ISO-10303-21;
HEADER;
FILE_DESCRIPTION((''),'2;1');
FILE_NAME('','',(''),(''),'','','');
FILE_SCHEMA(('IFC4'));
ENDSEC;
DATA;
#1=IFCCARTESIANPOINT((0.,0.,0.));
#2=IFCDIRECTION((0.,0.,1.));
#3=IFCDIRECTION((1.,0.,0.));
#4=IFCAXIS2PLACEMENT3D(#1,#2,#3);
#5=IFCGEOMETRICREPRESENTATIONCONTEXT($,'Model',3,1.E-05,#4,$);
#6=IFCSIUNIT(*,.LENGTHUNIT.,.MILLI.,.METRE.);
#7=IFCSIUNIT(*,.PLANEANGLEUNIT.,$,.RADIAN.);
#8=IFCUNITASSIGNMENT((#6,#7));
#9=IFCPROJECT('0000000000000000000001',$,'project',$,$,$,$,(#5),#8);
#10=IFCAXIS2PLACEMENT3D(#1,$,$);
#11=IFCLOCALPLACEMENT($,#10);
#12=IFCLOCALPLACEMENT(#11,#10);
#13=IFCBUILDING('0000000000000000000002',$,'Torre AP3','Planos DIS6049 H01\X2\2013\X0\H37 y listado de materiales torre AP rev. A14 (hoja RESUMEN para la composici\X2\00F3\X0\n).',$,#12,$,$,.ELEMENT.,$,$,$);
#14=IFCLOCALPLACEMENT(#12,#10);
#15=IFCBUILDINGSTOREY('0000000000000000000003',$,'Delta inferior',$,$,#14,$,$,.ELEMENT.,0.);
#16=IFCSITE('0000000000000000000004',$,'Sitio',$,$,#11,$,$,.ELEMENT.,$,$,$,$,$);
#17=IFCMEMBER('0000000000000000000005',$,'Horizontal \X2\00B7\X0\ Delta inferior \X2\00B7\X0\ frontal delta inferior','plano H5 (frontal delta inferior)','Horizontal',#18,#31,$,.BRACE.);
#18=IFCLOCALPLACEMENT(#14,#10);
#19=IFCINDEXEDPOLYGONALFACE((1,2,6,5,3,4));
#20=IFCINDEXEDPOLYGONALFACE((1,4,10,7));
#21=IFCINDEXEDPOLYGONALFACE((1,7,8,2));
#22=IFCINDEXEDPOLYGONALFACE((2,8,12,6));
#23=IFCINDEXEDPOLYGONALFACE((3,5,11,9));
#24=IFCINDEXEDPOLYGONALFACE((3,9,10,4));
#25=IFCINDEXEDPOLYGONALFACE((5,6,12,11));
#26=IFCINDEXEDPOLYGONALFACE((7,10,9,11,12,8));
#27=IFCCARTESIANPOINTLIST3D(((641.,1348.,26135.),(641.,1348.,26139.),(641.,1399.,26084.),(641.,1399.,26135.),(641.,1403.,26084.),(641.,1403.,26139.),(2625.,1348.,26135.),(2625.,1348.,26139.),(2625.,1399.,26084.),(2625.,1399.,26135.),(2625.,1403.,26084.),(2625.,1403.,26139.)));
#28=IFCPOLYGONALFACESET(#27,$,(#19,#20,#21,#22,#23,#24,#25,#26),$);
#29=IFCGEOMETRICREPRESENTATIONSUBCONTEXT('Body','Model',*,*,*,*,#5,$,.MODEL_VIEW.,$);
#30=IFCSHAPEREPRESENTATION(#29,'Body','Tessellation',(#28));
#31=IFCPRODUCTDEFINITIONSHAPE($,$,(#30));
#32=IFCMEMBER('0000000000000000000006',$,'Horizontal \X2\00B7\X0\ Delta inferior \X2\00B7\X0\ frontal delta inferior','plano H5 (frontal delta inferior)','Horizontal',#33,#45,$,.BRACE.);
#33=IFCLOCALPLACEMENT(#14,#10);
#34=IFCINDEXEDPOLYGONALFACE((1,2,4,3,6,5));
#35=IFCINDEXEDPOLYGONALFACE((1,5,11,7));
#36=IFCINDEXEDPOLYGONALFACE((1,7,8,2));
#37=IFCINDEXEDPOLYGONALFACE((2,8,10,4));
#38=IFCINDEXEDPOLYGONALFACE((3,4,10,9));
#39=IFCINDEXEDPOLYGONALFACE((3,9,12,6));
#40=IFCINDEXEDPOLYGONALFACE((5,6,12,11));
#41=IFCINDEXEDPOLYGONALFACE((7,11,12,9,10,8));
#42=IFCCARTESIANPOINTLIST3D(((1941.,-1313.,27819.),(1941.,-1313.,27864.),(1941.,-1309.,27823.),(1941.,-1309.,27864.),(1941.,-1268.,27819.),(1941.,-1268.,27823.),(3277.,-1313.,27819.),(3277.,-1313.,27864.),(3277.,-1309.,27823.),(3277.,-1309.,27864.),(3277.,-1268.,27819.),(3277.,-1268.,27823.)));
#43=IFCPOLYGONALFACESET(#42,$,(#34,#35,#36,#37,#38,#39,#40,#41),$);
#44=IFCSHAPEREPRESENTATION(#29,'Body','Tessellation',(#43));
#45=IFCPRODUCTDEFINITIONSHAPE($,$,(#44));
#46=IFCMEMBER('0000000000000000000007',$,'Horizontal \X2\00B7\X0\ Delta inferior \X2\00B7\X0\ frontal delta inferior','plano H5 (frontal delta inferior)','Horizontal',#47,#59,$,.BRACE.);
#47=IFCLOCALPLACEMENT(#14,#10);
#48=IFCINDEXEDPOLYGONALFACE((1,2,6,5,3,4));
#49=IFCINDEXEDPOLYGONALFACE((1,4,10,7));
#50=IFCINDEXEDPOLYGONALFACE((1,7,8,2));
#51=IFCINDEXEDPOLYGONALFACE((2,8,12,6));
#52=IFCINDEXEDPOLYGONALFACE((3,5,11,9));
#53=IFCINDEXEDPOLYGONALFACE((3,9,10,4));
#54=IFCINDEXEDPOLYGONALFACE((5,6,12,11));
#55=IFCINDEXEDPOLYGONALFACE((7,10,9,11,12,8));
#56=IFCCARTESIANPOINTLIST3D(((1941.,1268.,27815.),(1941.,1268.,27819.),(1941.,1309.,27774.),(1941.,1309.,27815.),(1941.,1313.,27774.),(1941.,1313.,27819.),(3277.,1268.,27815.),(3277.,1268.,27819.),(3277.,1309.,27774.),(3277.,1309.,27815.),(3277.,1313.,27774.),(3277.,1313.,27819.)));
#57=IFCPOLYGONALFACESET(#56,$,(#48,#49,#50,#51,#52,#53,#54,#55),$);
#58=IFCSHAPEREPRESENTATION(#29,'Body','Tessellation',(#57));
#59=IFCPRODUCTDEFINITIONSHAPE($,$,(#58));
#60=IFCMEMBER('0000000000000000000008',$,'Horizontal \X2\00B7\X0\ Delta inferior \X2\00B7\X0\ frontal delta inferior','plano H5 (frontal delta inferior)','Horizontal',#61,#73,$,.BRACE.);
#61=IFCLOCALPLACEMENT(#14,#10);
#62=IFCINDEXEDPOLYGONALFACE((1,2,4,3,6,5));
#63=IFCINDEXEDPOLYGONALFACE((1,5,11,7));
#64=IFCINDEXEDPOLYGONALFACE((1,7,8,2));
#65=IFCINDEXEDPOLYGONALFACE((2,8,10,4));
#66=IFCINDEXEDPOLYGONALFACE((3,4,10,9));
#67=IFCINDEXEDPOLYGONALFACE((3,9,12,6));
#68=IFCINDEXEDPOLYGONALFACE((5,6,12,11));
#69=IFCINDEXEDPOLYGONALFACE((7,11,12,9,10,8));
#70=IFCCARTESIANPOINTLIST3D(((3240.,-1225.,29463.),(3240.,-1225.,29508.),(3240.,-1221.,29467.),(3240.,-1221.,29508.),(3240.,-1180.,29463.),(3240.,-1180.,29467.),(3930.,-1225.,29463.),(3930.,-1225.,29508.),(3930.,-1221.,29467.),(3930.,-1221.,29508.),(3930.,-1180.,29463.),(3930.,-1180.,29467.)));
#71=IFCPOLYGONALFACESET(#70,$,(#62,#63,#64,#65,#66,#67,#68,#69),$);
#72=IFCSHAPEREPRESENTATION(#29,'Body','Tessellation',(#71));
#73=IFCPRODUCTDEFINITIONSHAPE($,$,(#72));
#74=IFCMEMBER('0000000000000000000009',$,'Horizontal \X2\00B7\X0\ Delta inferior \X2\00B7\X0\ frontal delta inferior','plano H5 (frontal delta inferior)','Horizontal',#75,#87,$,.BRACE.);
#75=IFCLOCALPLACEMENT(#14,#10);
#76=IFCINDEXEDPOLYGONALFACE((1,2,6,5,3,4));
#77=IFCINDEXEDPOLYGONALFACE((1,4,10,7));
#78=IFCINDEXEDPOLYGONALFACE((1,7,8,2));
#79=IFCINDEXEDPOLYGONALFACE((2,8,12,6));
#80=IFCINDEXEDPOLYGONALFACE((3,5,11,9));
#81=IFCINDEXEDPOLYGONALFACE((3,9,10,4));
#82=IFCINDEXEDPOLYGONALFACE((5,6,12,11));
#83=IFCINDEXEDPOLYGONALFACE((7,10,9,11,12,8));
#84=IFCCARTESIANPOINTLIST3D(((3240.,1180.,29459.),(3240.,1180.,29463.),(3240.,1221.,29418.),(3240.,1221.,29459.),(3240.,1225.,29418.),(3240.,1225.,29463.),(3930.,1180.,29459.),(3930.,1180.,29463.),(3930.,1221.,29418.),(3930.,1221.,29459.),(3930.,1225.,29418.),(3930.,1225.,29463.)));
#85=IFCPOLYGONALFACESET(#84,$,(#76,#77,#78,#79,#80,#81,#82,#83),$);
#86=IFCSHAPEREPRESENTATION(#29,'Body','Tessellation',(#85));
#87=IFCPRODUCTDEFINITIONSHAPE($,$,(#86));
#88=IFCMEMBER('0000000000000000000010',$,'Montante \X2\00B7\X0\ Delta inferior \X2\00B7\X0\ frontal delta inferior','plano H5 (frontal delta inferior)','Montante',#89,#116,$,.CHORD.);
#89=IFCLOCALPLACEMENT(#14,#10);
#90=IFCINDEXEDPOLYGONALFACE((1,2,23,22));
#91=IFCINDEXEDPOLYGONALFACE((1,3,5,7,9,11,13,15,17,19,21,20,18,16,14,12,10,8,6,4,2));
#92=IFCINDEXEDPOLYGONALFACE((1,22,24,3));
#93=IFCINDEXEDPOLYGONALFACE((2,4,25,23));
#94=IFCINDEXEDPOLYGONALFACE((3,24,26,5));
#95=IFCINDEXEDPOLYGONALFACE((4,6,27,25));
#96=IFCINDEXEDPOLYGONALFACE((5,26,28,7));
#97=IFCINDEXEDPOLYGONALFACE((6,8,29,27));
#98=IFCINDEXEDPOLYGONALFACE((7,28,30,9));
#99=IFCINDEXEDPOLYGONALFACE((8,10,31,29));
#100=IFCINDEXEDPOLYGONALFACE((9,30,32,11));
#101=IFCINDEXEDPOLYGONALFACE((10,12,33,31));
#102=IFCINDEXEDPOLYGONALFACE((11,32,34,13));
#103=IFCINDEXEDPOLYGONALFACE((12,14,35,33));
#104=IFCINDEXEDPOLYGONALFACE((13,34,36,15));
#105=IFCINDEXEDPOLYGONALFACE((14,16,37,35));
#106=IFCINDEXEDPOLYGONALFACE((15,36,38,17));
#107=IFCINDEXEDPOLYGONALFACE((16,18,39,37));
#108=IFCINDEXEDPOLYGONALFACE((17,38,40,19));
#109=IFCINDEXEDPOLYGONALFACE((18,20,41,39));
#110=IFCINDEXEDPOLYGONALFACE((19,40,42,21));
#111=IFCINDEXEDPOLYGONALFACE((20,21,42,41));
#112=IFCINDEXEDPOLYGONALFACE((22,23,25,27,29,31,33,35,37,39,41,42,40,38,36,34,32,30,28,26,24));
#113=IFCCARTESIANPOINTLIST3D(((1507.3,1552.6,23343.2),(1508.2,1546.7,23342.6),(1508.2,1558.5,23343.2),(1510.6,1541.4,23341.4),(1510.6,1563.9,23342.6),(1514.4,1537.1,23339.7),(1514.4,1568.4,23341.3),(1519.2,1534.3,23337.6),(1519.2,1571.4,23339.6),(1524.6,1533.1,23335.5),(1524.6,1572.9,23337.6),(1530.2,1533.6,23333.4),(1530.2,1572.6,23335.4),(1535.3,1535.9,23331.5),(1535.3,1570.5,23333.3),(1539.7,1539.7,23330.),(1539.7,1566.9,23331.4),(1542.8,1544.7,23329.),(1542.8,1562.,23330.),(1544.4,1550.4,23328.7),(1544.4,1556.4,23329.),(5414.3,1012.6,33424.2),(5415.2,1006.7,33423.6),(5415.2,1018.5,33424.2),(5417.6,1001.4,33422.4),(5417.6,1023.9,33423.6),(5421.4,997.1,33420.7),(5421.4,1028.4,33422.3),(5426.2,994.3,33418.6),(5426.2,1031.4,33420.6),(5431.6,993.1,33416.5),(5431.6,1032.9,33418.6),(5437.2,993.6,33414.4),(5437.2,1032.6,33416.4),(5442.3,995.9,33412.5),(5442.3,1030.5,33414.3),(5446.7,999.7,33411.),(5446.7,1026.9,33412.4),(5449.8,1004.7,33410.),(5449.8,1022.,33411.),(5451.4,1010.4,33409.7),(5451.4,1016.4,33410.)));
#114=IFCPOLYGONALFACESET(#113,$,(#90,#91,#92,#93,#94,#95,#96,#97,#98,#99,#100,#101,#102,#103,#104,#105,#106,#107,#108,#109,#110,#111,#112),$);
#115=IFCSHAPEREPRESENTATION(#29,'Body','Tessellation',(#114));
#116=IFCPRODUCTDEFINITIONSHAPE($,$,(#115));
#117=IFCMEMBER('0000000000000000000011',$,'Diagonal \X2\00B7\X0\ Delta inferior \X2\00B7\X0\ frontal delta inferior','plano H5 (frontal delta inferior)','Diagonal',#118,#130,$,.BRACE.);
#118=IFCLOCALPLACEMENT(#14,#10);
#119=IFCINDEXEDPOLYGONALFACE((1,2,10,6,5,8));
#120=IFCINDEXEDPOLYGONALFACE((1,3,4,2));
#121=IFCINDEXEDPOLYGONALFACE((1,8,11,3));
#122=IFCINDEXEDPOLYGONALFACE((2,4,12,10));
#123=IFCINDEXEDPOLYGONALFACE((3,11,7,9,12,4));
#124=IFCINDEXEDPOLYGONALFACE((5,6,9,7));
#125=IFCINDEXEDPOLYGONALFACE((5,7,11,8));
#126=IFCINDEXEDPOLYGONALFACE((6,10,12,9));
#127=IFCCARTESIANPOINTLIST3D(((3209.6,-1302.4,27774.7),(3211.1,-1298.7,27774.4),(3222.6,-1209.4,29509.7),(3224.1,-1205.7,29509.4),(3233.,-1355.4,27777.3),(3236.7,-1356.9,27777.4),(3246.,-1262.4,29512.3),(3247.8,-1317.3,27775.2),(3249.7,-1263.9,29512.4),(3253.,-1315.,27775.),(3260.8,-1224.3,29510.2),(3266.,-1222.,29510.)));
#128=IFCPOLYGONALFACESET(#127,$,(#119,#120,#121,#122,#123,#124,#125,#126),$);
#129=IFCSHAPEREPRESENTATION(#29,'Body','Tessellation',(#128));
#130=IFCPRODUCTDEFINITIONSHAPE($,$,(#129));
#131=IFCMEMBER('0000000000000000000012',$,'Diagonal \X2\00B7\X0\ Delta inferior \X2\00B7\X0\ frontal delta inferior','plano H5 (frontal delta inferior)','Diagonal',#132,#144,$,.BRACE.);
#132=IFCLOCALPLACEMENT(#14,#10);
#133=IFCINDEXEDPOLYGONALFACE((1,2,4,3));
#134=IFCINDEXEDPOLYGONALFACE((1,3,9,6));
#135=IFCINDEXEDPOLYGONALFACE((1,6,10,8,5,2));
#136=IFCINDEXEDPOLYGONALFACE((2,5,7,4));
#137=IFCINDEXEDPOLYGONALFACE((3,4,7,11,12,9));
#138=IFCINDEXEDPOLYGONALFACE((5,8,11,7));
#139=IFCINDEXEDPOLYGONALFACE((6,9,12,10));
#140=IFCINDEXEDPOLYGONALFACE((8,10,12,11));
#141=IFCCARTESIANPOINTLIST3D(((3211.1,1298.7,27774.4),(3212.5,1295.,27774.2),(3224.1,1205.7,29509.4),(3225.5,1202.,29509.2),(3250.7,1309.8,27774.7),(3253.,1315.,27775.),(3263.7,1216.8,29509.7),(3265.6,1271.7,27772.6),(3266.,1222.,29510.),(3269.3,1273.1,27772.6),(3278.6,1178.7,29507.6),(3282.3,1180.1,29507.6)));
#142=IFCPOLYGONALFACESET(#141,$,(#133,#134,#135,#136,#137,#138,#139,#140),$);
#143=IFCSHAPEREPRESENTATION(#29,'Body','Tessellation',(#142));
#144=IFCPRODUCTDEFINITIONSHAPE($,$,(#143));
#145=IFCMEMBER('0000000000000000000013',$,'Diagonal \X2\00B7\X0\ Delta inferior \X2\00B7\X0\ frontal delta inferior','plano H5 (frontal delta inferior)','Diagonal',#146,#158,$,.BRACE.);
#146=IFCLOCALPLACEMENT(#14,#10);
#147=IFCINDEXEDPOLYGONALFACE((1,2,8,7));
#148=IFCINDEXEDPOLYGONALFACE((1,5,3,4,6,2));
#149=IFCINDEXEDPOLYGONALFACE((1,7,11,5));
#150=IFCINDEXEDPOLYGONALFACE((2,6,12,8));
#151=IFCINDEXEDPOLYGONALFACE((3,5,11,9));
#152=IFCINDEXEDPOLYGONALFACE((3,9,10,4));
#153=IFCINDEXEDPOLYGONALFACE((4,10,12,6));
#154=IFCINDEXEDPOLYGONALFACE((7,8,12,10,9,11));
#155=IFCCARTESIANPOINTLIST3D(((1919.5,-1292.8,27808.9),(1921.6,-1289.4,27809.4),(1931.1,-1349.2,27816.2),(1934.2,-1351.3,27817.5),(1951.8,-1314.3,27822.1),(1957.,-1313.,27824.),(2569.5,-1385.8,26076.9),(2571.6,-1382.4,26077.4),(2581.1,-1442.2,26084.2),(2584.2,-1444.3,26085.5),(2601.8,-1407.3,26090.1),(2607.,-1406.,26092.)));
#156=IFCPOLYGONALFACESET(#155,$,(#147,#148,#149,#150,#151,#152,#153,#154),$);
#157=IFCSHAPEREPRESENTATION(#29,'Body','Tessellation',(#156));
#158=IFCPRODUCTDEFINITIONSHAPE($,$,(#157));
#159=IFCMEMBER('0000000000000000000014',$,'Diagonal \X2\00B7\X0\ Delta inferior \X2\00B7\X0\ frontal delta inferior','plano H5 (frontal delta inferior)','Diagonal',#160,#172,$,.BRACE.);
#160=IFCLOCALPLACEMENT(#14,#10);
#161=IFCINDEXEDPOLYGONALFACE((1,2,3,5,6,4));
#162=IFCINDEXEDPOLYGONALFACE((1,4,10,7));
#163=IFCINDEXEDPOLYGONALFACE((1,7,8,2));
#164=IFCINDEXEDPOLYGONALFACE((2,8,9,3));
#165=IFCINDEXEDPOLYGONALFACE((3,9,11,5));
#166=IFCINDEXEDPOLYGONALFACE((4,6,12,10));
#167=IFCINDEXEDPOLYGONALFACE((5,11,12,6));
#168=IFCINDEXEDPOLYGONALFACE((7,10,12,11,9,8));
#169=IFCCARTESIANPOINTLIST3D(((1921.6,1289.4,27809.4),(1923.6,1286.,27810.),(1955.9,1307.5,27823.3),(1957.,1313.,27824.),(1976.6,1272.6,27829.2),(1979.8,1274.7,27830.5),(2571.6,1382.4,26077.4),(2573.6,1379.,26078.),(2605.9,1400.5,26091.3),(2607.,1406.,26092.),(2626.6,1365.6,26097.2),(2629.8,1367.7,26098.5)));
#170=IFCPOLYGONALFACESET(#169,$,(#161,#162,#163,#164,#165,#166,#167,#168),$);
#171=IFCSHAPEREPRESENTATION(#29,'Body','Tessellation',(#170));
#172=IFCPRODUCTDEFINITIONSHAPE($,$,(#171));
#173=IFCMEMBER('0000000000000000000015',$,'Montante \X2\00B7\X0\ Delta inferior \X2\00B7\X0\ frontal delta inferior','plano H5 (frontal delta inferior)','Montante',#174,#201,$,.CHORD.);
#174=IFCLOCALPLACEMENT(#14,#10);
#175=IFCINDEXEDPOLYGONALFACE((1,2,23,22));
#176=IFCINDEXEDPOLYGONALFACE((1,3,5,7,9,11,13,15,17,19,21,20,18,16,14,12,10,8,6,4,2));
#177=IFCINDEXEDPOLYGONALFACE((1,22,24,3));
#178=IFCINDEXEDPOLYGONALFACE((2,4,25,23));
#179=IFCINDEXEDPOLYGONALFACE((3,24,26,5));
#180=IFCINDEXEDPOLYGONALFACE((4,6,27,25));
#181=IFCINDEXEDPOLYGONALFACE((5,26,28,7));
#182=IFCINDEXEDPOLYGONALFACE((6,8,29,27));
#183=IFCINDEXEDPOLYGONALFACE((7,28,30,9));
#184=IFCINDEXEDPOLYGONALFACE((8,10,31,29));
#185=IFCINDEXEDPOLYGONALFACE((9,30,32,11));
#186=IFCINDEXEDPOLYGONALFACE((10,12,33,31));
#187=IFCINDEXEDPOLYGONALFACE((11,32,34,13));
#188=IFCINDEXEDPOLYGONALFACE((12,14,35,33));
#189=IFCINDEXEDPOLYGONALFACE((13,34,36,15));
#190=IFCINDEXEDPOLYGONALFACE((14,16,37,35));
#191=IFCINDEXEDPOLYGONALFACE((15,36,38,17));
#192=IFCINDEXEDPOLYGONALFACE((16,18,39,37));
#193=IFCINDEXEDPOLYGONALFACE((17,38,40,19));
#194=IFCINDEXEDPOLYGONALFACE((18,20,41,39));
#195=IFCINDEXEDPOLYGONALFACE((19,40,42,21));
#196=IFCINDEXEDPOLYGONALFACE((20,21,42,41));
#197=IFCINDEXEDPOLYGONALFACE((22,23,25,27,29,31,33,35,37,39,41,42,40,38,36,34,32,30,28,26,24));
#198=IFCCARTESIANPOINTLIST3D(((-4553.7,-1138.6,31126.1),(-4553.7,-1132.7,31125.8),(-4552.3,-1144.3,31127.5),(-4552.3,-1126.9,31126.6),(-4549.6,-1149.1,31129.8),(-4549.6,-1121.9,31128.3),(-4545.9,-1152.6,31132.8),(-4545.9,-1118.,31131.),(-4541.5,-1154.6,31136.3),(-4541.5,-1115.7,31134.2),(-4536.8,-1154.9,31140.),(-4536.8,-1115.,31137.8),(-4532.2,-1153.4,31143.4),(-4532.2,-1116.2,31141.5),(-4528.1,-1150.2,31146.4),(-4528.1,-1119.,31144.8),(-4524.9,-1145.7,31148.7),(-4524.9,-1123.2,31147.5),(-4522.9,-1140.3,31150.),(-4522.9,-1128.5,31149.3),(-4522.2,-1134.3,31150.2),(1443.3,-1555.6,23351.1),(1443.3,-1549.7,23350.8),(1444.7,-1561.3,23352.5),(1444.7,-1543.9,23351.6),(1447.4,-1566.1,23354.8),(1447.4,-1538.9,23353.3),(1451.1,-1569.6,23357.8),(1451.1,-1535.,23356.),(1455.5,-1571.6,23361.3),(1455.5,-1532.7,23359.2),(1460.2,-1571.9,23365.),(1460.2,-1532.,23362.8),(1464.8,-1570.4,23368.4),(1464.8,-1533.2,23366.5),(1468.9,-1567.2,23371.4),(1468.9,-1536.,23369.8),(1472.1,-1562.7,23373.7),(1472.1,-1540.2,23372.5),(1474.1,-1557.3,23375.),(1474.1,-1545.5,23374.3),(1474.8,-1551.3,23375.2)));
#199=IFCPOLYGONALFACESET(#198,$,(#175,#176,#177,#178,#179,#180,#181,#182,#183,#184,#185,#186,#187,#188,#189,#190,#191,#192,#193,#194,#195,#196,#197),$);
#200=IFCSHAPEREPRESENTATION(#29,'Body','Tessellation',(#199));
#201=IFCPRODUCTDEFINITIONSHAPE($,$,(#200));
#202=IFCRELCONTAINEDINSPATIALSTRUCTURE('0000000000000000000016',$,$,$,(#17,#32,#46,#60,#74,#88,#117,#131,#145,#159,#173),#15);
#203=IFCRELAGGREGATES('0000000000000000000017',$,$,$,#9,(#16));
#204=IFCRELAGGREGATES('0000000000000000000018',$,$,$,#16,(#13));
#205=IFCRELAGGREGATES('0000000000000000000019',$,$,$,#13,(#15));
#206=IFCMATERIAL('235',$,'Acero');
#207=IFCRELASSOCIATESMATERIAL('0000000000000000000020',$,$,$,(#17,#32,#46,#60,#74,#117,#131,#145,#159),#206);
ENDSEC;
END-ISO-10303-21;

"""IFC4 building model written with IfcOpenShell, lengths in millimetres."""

from ifc_helpers import new_model, si_unit, frame, frame_2d, origin, origin_with_axes, place, context, subcontext, project, spatial, circle, l_section, extrude, material, element, save


model = new_model("IFC4")

# Units and contexts
model_context = context("Model", 3, precision=1e-05, world=origin_with_axes())
body_context = subcontext(model_context, "Body", "Model", "MODEL_VIEW")
ifc_project = project(units=[si_unit("LENGTHUNIT", "METRE", prefix="MILLI"), si_unit("PLANEANGLEUNIT", "RADIAN")], contexts=[model_context])

# Site, building, storey
site_placement = place(None, origin())
site = spatial("IfcSite", under=ifc_project, at=site_placement, Name="Sitio", CompositionType="ELEMENT")
building_placement = place(site_placement, origin())
building = spatial("IfcBuilding", under=site, at=building_placement, Name="Torre AP3", Description="Planos DIS6049 H01–H37 y listado de materiales torre AP rev. A14 (hoja RESUMEN para la composición).", CompositionType="ELEMENT")
storey_placement = place(building_placement, origin())
storey = spatial("IfcBuildingStorey", under=building, at=storey_placement, Name="Delta inferior", CompositionType="ELEMENT", Elevation=0.0)

# Members
ifc_material_1 = material(Name="235", Category="Acero")
member_1_placement = place(storey_placement, frame((641.0, 1403.0, 26139.0), z_axis=(1.0, 0.0, 0.0), x_axis=(0.0, -1.0, 0.0)))
element("IfcMember", 1, at=member_1_placement, inside=storey, material=ifc_material_1, Name="Horizontal · Delta inferior · frontal delta inferior", Description="plano H5 (frontal delta inferior)", ObjectType="Horizontal", PredefinedType="BRACE", context=body_context, shape_type="SweptSolid", body=[
    extrude(l_section(Depth=55.0, Width=55.0, Thickness=4.0, at=frame_2d((27.5, 27.5))), None, (0.0, 0.0, 1.0), 1984.0),
])
for number, where, z_axis, x_axis, name in (
    (2, (1941.0, -1313.0, 27819.0), (1.0, 0.0, 0.0), (0.0, 1.0, 0.0), "Horizontal · Delta inferior · frontal delta inferior"),
    (3, (1941.0, 1313.0, 27819.0), (1.0, 0.0, 0.0), (0.0, -1.0, 0.0), "Horizontal · Delta inferior · frontal delta inferior"),
):
    element("IfcMember", number, at=place(storey_placement, frame(where, z_axis=z_axis, x_axis=x_axis)), inside=storey, material=ifc_material_1, Name=name, Description="plano H5 (frontal delta inferior)", ObjectType="Horizontal", PredefinedType="BRACE", context=body_context, shape_type="SweptSolid", body=[
        extrude(l_section(Depth=45.0, Width=45.0, Thickness=4.0, at=frame_2d((22.5, 22.5))), None, (0.0, 0.0, 1.0), 1336.0),
    ])
for number, where, z_axis, x_axis, name in (
    (4, (3240.0, -1225.0, 29463.0), (1.0, 0.0, 0.0), (0.0, 1.0, 0.0), "Horizontal · Delta inferior · frontal delta inferior"),
    (5, (3240.0, 1225.0, 29463.0), (1.0, 0.0, 0.0), (0.0, -1.0, 0.0), "Horizontal · Delta inferior · frontal delta inferior"),
):
    element("IfcMember", number, at=place(storey_placement, frame(where, z_axis=z_axis, x_axis=x_axis)), inside=storey, material=ifc_material_1, Name=name, Description="plano H5 (frontal delta inferior)", ObjectType="Horizontal", PredefinedType="BRACE", context=body_context, shape_type="SweptSolid", body=[
        extrude(l_section(Depth=45.0, Width=45.0, Thickness=4.0, at=frame_2d((22.5, 22.5))), None, (0.0, 0.0, 1.0), 690.0),
    ])
for number, where, z_axis, x_axis, name in (
    (6, (1526.0, 1553.0, 23336.0), (0.36092, -0.049884, 0.931262), (-0.932597, -0.019305, 0.360404), "Montante · Delta inferior · frontal delta inferior"),
):
    element("IfcMember", number, at=place(storey_placement, frame(where, z_axis=z_axis, x_axis=x_axis)), inside=storey, Name=name, Description="plano H5 (frontal delta inferior)", ObjectType="Montante", PredefinedType="CHORD", context=body_context, shape_type="SweptSolid", body=[
        extrude(circle(Radius=20.0), None, (0.0, 0.0, 1.0), 10825.1),
    ])
for number, where, z_axis, x_axis, name in (
    (7, (3253.0, -1315.0, 27775.0), (0.007482, 0.053524, 0.998539), (-0.932081, 0.362036, -0.012422), "Diagonal · Delta inferior · frontal delta inferior"),
    (8, (3253.0, 1315.0, 27775.0), (0.007482, -0.053524, 0.998539), (-0.932081, -0.362036, -0.012422), "Diagonal · Delta inferior · frontal delta inferior"),
):
    element("IfcMember", number, at=place(storey_placement, frame(where, z_axis=z_axis, x_axis=x_axis)), inside=storey, material=ifc_material_1, Name=name, Description="plano H5 (frontal delta inferior)", ObjectType="Diagonal", PredefinedType="BRACE", context=body_context, shape_type="SweptSolid", body=[
        extrude(l_section(Depth=45.0, Width=45.0, Thickness=4.0, at=frame_2d((22.5, 22.5))), None, (0.0, 0.0, 1.0), 1737.5),
    ])
for number, where, z_axis, x_axis, name in (
    (9, (2607.0, -1406.0, 26092.0), (-0.350917, 0.050208, 0.935059), (-0.787637, 0.524232, -0.32374), "Diagonal · Delta inferior · frontal delta inferior"),
    (10, (2607.0, 1406.0, 26092.0), (-0.350917, -0.050208, 0.935059), (-0.787637, -0.524232, -0.32374), "Diagonal · Delta inferior · frontal delta inferior"),
):
    element("IfcMember", number, at=place(storey_placement, frame(where, z_axis=z_axis, x_axis=x_axis)), inside=storey, material=ifc_material_1, Name=name, Description="plano H5 (frontal delta inferior)", ObjectType="Diagonal", PredefinedType="BRACE", context=body_context, shape_type="SweptSolid", body=[
        extrude(l_section(Depth=45.0, Width=45.0, Thickness=4.0, at=frame_2d((22.5, 22.5))), None, (0.0, 0.0, 1.0), 1852.3),
    ])
for number, where, z_axis, x_axis, name in (
    (11, (1459.0, -1552.0, 23363.0), (-0.610199, 0.04243, 0.791111), (0.792248, 0.03268, 0.609323), "Montante · Delta inferior · frontal delta inferior"),
):
    element("IfcMember", number, at=place(storey_placement, frame(where, z_axis=z_axis, x_axis=x_axis)), inside=storey, Name=name, Description="plano H5 (frontal delta inferior)", ObjectType="Montante", PredefinedType="CHORD", context=body_context, shape_type="SweptSolid", body=[
        extrude(circle(Radius=20.0), None, (0.0, 0.0, 1.0), 9827.9),
    ])

save(model, "model.ifc")
